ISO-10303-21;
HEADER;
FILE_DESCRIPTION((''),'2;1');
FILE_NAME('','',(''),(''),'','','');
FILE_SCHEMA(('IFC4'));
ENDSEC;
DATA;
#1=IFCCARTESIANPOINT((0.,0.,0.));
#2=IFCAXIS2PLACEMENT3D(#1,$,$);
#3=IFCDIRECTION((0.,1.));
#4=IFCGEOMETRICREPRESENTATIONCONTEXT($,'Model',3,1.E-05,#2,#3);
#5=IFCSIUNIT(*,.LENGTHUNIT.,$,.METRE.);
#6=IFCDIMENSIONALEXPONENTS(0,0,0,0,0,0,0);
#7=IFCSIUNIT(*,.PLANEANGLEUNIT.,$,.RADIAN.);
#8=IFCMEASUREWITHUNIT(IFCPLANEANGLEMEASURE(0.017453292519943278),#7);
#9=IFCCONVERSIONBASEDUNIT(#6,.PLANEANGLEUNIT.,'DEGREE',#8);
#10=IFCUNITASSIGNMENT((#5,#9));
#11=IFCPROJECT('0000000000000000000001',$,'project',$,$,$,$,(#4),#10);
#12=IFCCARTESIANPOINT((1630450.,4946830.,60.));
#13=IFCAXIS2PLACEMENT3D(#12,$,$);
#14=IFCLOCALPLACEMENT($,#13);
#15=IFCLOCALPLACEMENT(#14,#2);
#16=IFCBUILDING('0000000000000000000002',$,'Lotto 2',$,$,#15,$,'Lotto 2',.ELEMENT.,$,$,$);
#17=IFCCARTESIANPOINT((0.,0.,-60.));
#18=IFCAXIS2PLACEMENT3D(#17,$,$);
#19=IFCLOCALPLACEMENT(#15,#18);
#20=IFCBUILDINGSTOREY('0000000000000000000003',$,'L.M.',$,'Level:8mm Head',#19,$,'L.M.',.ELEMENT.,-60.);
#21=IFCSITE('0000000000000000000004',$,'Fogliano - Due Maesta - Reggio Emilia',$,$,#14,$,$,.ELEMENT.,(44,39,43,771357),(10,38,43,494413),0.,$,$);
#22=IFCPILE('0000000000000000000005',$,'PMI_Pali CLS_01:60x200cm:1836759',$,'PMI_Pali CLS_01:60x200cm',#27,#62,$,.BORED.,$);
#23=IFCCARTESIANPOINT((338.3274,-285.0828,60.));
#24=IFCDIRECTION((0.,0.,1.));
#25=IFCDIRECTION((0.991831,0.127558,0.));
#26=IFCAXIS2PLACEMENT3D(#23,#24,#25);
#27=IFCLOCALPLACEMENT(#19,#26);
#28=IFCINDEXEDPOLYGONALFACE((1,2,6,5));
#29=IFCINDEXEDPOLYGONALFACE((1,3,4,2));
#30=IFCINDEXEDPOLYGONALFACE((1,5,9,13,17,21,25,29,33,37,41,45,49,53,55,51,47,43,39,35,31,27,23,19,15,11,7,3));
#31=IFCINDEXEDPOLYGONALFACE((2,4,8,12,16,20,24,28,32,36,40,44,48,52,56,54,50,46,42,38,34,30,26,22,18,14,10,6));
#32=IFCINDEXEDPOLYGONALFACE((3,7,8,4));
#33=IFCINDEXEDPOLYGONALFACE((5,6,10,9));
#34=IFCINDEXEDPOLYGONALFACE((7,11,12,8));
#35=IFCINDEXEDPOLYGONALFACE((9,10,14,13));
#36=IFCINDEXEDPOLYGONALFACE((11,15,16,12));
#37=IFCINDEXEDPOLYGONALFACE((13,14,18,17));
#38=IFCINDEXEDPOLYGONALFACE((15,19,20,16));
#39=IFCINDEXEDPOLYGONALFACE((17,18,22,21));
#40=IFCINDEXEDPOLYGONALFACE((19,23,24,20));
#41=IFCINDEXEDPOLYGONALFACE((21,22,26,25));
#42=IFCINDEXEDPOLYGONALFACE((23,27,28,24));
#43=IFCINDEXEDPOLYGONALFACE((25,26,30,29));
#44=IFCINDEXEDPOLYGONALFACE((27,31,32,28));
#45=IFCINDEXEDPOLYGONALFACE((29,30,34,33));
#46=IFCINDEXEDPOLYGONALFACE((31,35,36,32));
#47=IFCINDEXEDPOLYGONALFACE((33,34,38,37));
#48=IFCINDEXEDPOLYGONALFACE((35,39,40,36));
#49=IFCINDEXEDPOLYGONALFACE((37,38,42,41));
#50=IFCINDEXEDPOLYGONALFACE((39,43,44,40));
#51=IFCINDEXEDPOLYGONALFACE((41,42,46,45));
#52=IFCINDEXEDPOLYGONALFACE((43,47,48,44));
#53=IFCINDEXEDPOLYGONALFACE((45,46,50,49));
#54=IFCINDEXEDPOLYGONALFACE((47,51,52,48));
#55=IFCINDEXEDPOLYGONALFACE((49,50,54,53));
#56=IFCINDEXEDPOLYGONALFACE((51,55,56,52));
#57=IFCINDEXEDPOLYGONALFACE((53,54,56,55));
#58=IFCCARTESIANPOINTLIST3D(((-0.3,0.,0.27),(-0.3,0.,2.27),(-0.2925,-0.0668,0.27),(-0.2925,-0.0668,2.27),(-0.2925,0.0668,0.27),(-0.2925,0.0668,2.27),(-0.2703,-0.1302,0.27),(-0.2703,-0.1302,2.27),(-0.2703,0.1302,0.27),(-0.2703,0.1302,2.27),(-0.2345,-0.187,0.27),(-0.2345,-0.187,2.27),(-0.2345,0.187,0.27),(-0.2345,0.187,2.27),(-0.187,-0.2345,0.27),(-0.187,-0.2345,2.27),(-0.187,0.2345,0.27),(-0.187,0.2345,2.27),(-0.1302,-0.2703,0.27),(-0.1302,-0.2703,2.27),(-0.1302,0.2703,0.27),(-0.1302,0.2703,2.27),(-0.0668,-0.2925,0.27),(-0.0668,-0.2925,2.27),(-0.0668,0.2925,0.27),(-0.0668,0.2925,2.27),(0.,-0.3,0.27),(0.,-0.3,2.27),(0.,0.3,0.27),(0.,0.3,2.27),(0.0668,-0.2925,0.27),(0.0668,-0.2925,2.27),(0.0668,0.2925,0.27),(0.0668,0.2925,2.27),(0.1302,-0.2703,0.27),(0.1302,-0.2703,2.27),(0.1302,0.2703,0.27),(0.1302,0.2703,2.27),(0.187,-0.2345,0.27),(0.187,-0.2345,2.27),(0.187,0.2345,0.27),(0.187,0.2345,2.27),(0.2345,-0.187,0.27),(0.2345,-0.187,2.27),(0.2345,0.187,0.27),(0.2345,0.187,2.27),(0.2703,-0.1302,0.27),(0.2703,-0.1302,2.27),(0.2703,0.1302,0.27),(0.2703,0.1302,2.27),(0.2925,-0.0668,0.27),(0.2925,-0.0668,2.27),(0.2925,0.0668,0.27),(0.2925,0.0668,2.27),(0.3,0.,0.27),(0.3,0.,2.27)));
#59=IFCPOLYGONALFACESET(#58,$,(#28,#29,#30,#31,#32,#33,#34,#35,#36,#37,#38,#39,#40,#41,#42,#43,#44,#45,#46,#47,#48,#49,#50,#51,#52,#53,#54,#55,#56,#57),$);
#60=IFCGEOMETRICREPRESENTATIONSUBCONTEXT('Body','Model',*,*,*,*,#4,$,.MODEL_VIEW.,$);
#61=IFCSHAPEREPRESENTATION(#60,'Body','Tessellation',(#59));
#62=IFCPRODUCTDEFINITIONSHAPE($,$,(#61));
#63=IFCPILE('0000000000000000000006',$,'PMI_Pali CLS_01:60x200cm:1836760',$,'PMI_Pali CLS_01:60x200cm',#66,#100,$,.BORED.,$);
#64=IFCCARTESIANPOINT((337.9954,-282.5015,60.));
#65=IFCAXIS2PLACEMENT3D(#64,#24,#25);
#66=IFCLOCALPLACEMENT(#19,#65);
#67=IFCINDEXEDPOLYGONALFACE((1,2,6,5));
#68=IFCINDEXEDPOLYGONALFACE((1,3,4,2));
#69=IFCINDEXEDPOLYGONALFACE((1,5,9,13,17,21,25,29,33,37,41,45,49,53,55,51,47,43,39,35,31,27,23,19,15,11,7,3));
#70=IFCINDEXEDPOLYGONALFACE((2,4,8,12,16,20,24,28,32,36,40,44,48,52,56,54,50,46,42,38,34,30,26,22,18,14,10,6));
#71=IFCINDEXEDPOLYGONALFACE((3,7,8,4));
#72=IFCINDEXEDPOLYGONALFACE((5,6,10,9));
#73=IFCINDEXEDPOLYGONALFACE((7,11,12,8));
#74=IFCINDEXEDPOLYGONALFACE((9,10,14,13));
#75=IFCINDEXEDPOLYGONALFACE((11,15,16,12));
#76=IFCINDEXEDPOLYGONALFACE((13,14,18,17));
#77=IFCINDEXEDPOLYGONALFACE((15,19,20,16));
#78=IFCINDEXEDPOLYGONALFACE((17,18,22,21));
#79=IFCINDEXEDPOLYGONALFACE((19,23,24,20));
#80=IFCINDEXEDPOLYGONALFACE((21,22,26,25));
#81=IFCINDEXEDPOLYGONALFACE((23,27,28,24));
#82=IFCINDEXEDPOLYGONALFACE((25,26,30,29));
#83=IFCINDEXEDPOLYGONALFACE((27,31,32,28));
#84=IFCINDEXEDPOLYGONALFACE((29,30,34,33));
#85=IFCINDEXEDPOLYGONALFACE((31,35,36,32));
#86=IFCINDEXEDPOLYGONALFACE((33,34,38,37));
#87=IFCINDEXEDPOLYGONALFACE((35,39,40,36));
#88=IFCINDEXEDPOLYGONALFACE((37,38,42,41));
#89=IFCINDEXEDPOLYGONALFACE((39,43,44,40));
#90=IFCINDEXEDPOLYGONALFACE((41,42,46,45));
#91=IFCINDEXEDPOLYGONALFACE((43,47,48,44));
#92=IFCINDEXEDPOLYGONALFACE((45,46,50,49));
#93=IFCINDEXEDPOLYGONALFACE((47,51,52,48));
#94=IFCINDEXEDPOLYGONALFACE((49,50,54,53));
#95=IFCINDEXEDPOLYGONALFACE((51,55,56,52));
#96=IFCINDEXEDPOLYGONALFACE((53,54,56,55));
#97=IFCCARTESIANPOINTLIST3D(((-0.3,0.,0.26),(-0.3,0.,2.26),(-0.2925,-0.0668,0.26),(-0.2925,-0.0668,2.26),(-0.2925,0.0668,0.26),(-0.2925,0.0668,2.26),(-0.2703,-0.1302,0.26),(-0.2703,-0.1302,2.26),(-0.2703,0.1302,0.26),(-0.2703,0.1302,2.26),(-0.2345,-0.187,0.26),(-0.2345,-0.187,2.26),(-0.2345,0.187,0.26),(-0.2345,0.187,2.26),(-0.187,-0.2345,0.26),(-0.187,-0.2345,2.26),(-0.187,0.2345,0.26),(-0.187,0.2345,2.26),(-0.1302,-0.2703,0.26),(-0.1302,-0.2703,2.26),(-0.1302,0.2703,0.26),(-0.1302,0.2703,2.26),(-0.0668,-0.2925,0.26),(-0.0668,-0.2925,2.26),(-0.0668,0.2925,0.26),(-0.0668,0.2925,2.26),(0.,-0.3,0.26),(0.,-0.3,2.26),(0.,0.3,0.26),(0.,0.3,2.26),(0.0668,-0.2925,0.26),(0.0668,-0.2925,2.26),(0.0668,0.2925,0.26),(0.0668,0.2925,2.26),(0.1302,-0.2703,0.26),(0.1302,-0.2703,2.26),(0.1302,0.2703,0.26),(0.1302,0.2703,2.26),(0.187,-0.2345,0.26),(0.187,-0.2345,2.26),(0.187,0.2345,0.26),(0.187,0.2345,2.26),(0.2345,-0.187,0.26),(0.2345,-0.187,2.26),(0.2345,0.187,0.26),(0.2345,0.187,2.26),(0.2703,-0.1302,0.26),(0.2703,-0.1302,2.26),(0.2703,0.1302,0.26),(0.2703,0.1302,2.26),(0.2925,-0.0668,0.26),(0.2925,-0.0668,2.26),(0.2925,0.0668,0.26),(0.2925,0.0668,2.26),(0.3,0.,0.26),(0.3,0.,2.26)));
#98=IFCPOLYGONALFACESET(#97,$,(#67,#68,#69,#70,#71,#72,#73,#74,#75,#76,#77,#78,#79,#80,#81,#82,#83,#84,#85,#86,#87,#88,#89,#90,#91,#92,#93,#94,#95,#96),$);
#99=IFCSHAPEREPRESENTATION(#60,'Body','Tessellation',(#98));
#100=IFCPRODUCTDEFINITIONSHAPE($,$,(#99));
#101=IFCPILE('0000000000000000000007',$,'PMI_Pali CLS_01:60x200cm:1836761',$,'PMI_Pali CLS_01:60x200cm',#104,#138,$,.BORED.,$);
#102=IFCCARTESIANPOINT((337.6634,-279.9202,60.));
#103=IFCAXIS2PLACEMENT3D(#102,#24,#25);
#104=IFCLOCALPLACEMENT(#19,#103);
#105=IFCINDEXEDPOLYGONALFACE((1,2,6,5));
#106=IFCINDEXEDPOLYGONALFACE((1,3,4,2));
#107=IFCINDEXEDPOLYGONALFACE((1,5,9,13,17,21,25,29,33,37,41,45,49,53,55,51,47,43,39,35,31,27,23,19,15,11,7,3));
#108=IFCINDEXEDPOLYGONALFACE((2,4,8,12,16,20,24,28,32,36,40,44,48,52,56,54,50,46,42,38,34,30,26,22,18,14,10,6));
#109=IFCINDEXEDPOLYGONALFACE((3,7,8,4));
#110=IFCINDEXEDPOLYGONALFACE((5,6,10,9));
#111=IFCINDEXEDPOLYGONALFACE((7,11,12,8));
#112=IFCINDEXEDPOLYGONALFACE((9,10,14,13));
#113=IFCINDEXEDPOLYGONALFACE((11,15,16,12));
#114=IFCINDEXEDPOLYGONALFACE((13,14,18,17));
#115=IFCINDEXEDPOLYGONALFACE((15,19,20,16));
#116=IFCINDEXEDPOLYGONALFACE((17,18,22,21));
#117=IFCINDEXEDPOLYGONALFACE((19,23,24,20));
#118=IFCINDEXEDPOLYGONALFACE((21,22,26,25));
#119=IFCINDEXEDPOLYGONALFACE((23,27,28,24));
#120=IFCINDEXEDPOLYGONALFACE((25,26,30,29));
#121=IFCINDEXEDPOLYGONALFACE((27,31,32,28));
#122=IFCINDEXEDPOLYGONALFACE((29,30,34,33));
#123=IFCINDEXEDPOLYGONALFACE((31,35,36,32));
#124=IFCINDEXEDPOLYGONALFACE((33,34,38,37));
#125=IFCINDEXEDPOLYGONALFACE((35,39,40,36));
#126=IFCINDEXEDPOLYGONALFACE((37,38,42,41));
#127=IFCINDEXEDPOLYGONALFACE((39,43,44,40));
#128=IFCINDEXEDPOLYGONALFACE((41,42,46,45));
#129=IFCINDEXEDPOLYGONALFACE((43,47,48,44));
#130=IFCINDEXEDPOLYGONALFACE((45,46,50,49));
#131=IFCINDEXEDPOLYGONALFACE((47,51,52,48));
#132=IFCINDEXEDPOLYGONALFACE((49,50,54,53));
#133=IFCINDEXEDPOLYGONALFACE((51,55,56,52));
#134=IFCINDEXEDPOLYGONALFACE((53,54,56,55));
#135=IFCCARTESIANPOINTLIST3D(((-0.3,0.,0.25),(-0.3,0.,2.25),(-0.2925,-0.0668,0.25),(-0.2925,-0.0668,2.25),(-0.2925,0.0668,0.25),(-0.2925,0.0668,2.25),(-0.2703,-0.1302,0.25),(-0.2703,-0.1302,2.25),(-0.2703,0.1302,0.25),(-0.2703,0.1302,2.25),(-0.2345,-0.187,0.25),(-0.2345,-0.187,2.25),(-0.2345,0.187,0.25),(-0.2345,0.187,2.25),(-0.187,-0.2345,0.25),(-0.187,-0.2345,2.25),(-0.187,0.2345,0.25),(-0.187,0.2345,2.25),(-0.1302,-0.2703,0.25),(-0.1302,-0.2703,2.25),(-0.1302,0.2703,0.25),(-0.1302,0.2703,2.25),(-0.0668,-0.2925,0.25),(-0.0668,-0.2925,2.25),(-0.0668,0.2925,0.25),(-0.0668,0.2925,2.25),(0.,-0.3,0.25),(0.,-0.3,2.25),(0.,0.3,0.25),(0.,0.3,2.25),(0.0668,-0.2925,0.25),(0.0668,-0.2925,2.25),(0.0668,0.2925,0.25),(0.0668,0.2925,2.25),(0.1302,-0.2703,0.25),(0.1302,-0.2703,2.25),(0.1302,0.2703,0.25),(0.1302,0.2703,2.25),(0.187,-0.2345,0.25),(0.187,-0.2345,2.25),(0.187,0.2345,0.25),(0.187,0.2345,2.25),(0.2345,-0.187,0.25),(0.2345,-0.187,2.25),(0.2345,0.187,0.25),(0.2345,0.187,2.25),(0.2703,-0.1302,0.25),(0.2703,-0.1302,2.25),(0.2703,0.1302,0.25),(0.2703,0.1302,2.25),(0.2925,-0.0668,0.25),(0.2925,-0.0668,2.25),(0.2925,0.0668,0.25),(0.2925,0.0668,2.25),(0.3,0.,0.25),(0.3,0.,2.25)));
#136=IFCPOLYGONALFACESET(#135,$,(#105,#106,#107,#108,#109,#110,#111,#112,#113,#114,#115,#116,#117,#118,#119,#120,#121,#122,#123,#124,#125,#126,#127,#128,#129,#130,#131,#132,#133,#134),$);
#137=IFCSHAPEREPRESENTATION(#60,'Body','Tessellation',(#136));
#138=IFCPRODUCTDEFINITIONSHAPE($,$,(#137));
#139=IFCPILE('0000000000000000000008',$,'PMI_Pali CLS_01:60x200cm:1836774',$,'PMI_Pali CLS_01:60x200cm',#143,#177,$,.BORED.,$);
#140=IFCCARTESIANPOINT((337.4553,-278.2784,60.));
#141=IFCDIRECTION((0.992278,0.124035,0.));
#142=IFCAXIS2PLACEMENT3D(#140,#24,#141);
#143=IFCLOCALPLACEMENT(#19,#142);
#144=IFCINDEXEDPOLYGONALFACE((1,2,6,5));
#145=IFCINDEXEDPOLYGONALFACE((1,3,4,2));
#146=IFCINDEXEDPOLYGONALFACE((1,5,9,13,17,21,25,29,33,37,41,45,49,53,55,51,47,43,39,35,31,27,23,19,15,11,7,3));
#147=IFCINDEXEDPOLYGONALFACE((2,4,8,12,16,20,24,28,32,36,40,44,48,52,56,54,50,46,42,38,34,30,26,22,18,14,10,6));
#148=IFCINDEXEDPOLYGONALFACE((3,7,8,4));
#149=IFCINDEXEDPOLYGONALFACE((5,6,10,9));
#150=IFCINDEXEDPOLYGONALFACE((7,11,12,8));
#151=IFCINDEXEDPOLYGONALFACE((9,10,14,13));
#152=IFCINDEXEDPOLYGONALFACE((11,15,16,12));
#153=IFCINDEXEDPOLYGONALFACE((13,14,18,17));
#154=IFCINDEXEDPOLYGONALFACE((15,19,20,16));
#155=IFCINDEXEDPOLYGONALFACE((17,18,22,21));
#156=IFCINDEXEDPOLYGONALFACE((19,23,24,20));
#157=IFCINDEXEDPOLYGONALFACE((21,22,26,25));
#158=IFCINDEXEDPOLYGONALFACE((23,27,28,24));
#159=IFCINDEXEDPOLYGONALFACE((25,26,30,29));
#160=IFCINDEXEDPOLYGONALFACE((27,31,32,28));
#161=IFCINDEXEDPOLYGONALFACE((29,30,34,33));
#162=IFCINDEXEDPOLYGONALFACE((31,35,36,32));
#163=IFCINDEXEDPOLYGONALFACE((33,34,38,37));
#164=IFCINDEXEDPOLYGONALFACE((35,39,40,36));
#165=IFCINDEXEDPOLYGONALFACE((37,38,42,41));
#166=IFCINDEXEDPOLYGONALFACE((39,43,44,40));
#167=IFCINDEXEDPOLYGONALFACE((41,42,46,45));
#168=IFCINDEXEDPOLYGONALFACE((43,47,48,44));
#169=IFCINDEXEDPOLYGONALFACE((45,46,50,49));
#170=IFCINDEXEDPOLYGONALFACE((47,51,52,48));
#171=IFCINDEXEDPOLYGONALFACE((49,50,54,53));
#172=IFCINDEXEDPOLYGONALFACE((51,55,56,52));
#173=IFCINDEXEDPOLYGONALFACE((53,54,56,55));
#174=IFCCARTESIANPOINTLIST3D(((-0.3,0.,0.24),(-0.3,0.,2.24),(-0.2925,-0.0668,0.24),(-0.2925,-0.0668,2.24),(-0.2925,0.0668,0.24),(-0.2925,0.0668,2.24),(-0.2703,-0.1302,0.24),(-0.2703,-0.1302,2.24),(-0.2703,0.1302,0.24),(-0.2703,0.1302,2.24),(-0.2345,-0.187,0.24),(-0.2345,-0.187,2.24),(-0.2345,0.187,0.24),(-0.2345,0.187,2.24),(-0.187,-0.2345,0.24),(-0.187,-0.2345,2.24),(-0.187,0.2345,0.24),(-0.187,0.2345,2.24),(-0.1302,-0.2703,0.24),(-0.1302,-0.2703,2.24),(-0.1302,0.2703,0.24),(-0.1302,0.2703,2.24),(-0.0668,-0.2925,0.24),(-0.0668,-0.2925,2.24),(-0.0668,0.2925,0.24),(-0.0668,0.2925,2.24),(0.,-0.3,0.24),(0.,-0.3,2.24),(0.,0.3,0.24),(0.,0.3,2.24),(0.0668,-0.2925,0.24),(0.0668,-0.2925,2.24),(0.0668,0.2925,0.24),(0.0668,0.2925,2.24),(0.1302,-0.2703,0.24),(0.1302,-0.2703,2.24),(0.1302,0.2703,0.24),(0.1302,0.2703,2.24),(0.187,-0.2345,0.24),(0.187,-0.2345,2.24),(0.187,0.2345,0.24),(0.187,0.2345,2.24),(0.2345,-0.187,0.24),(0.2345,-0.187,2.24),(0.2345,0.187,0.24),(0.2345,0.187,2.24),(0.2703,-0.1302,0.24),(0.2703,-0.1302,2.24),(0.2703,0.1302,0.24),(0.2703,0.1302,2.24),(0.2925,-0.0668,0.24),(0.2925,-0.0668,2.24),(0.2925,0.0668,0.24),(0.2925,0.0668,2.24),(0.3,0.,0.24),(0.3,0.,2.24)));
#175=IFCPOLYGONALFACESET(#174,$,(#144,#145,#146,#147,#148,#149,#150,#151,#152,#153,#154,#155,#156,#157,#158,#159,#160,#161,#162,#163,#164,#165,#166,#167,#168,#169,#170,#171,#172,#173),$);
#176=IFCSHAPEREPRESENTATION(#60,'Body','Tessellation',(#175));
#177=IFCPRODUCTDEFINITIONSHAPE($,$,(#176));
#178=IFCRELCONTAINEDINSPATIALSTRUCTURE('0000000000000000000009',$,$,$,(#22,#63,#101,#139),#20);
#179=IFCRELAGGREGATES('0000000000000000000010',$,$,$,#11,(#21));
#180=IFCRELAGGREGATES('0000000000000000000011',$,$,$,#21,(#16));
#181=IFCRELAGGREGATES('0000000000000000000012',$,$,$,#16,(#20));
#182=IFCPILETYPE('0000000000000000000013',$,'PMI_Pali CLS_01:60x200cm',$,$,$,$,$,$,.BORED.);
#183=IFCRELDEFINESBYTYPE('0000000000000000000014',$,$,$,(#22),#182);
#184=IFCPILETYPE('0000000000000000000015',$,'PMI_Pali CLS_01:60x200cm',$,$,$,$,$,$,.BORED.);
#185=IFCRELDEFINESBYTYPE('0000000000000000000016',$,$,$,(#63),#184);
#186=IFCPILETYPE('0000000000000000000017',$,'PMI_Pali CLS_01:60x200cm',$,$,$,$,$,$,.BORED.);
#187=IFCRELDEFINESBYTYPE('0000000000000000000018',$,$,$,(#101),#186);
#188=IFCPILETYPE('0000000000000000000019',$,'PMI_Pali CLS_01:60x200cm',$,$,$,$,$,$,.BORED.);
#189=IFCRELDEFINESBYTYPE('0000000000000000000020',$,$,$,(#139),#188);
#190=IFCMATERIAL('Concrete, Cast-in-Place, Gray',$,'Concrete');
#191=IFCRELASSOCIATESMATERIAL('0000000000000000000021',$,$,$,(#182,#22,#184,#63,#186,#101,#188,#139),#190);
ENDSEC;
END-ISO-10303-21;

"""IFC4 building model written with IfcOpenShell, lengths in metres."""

from ifc_helpers import new_model, entity, si_unit, converted_unit, direction, frame, origin, place, context, subcontext, project, spatial, arc, indexed_curve, outline, extrude, source, transform, mapped, material, type_object, type_shapes, element, save


model = new_model("IFC4")

# Units and contexts
model_context = context("Model", 3, precision=1e-05, world=origin(), true_north=direction((0.0, 1.0)))
body_context = subcontext(model_context, "Body", "Model", "MODEL_VIEW")
ifc_project = project(units=[si_unit("LENGTHUNIT", "METRE"), converted_unit("PLANEANGLEUNIT", "DEGREE", entity("IfcPlaneAngleMeasure", 0.017453292519943278), si_unit("PLANEANGLEUNIT", "RADIAN"), dimensions=[0, 0, 0, 0, 0, 0, 0])], contexts=[model_context])

# Site, building, storey
site_placement = place(None, frame((1630450.0, 4946830.0, 60.0)))
site = spatial("IfcSite", under=ifc_project, at=site_placement, Name="Fogliano - Due Maesta - Reggio Emilia", CompositionType="ELEMENT", RefLatitude=(44, 39, 43, 771357), RefLongitude=(10, 38, 43, 494413), RefElevation=0.0)
building_placement = place(site_placement, origin())
building = spatial("IfcBuilding", under=site, at=building_placement, Name="Lotto 2", LongName="Lotto 2", CompositionType="ELEMENT")
storey_placement = place(building_placement, frame((0.0, 0.0, -60.0)))
storey = spatial("IfcBuildingStorey", under=building, at=storey_placement, Name="L.M.", ObjectType="Level:8mm Head", LongName="L.M.", CompositionType="ELEMENT", Elevation=-60.0)

# Piles
ifc_material_1 = material(Name="Concrete, Cast-in-Place, Gray", Category="Concrete")
pile_type_1 = type_object("IfcPileType", Name="PMI_Pali CLS_01:60x200cm", PredefinedType="BORED", material=ifc_material_1)
shared_shape_1 = source(origin(), body_context, "Body", "SweptSolid", [
    extrude(outline(indexed_curve([(-0.3, 0.0), (0.0, -0.3), (0.3, 0.0), (0.0, 0.3)], segments=[arc(1, 2, 3), arc(3, 4, 1)], self_intersect=False)), frame((0.0, 0.0, 0.27)), (0.0, 0.0, 1.0), 2.0),
])
type_shapes(pile_type_1, [shared_shape_1])
pile_1_placement = place(storey_placement, frame((338.3274, -285.0828, 60.0), z_axis=(0.0, 0.0, 1.0), x_axis=(0.991831, 0.127558, 0.0)))
element("IfcPile", 1, at=pile_1_placement, inside=storey, type_object=pile_type_1, material=ifc_material_1, Name="PMI_Pali CLS_01:60x200cm:1836759", ObjectType="PMI_Pali CLS_01:60x200cm", PredefinedType="BORED", context=body_context, shape_type="MappedRepresentation", body=[
    mapped(shared_shape_1, transform((0.0, 0.0, 0.0), scale=1.0)),
])
pile_type_2 = type_object("IfcPileType", Name="PMI_Pali CLS_01:60x200cm", PredefinedType="BORED", material=ifc_material_1)
shared_shape_2 = source(origin(), body_context, "Body", "SweptSolid", [
    extrude(outline(indexed_curve([(-0.3, 0.0), (0.0, -0.3), (0.3, 0.0), (0.0, 0.3)], segments=[arc(1, 2, 3), arc(3, 4, 1)], self_intersect=False)), frame((0.0, 0.0, 0.26)), (0.0, 0.0, 1.0), 2.0),
])
type_shapes(pile_type_2, [shared_shape_2])
pile_2_placement = place(storey_placement, frame((337.9954, -282.5015, 60.0), z_axis=(0.0, 0.0, 1.0), x_axis=(0.991831, 0.127558, 0.0)))
element("IfcPile", 2, at=pile_2_placement, inside=storey, type_object=pile_type_2, material=ifc_material_1, Name="PMI_Pali CLS_01:60x200cm:1836760", ObjectType="PMI_Pali CLS_01:60x200cm", PredefinedType="BORED", context=body_context, shape_type="MappedRepresentation", body=[
    mapped(shared_shape_2, transform((0.0, 0.0, 0.0), scale=1.0)),
])
pile_type_3 = type_object("IfcPileType", Name="PMI_Pali CLS_01:60x200cm", PredefinedType="BORED", material=ifc_material_1)
shared_shape_3 = source(origin(), body_context, "Body", "SweptSolid", [
    extrude(outline(indexed_curve([(-0.3, 0.0), (0.0, -0.3), (0.3, 0.0), (0.0, 0.3)], segments=[arc(1, 2, 3), arc(3, 4, 1)], self_intersect=False)), frame((0.0, 0.0, 0.25)), (0.0, 0.0, 1.0), 2.0),
])
type_shapes(pile_type_3, [shared_shape_3])
pile_3_placement = place(storey_placement, frame((337.6634, -279.9202, 60.0), z_axis=(0.0, 0.0, 1.0), x_axis=(0.991831, 0.127558, 0.0)))
element("IfcPile", 3, at=pile_3_placement, inside=storey, type_object=pile_type_3, material=ifc_material_1, Name="PMI_Pali CLS_01:60x200cm:1836761", ObjectType="PMI_Pali CLS_01:60x200cm", PredefinedType="BORED", context=body_context, shape_type="MappedRepresentation", body=[
    mapped(shared_shape_3, transform((0.0, 0.0, 0.0), scale=1.0)),
])
pile_type_4 = type_object("IfcPileType", Name="PMI_Pali CLS_01:60x200cm", PredefinedType="BORED", material=ifc_material_1)
shared_shape_4 = source(origin(), body_context, "Body", "SweptSolid", [
    extrude(outline(indexed_curve([(-0.3, 0.0), (0.0, -0.3), (0.3, 0.0), (0.0, 0.3)], segments=[arc(1, 2, 3), arc(3, 4, 1)], self_intersect=False)), frame((0.0, 0.0, 0.24)), (0.0, 0.0, 1.0), 2.0),
])
type_shapes(pile_type_4, [shared_shape_4])
pile_4_placement = place(storey_placement, frame((337.4553, -278.2784, 60.0), z_axis=(0.0, 0.0, 1.0), x_axis=(0.992278, 0.124035, 0.0)))
element("IfcPile", 4, at=pile_4_placement, inside=storey, type_object=pile_type_4, material=ifc_material_1, Name="PMI_Pali CLS_01:60x200cm:1836774", ObjectType="PMI_Pali CLS_01:60x200cm", PredefinedType="BORED", context=body_context, shape_type="MappedRepresentation", body=[
    mapped(shared_shape_4, transform((0.0, 0.0, 0.0), scale=1.0)),
])

save(model, "model.ifc")
